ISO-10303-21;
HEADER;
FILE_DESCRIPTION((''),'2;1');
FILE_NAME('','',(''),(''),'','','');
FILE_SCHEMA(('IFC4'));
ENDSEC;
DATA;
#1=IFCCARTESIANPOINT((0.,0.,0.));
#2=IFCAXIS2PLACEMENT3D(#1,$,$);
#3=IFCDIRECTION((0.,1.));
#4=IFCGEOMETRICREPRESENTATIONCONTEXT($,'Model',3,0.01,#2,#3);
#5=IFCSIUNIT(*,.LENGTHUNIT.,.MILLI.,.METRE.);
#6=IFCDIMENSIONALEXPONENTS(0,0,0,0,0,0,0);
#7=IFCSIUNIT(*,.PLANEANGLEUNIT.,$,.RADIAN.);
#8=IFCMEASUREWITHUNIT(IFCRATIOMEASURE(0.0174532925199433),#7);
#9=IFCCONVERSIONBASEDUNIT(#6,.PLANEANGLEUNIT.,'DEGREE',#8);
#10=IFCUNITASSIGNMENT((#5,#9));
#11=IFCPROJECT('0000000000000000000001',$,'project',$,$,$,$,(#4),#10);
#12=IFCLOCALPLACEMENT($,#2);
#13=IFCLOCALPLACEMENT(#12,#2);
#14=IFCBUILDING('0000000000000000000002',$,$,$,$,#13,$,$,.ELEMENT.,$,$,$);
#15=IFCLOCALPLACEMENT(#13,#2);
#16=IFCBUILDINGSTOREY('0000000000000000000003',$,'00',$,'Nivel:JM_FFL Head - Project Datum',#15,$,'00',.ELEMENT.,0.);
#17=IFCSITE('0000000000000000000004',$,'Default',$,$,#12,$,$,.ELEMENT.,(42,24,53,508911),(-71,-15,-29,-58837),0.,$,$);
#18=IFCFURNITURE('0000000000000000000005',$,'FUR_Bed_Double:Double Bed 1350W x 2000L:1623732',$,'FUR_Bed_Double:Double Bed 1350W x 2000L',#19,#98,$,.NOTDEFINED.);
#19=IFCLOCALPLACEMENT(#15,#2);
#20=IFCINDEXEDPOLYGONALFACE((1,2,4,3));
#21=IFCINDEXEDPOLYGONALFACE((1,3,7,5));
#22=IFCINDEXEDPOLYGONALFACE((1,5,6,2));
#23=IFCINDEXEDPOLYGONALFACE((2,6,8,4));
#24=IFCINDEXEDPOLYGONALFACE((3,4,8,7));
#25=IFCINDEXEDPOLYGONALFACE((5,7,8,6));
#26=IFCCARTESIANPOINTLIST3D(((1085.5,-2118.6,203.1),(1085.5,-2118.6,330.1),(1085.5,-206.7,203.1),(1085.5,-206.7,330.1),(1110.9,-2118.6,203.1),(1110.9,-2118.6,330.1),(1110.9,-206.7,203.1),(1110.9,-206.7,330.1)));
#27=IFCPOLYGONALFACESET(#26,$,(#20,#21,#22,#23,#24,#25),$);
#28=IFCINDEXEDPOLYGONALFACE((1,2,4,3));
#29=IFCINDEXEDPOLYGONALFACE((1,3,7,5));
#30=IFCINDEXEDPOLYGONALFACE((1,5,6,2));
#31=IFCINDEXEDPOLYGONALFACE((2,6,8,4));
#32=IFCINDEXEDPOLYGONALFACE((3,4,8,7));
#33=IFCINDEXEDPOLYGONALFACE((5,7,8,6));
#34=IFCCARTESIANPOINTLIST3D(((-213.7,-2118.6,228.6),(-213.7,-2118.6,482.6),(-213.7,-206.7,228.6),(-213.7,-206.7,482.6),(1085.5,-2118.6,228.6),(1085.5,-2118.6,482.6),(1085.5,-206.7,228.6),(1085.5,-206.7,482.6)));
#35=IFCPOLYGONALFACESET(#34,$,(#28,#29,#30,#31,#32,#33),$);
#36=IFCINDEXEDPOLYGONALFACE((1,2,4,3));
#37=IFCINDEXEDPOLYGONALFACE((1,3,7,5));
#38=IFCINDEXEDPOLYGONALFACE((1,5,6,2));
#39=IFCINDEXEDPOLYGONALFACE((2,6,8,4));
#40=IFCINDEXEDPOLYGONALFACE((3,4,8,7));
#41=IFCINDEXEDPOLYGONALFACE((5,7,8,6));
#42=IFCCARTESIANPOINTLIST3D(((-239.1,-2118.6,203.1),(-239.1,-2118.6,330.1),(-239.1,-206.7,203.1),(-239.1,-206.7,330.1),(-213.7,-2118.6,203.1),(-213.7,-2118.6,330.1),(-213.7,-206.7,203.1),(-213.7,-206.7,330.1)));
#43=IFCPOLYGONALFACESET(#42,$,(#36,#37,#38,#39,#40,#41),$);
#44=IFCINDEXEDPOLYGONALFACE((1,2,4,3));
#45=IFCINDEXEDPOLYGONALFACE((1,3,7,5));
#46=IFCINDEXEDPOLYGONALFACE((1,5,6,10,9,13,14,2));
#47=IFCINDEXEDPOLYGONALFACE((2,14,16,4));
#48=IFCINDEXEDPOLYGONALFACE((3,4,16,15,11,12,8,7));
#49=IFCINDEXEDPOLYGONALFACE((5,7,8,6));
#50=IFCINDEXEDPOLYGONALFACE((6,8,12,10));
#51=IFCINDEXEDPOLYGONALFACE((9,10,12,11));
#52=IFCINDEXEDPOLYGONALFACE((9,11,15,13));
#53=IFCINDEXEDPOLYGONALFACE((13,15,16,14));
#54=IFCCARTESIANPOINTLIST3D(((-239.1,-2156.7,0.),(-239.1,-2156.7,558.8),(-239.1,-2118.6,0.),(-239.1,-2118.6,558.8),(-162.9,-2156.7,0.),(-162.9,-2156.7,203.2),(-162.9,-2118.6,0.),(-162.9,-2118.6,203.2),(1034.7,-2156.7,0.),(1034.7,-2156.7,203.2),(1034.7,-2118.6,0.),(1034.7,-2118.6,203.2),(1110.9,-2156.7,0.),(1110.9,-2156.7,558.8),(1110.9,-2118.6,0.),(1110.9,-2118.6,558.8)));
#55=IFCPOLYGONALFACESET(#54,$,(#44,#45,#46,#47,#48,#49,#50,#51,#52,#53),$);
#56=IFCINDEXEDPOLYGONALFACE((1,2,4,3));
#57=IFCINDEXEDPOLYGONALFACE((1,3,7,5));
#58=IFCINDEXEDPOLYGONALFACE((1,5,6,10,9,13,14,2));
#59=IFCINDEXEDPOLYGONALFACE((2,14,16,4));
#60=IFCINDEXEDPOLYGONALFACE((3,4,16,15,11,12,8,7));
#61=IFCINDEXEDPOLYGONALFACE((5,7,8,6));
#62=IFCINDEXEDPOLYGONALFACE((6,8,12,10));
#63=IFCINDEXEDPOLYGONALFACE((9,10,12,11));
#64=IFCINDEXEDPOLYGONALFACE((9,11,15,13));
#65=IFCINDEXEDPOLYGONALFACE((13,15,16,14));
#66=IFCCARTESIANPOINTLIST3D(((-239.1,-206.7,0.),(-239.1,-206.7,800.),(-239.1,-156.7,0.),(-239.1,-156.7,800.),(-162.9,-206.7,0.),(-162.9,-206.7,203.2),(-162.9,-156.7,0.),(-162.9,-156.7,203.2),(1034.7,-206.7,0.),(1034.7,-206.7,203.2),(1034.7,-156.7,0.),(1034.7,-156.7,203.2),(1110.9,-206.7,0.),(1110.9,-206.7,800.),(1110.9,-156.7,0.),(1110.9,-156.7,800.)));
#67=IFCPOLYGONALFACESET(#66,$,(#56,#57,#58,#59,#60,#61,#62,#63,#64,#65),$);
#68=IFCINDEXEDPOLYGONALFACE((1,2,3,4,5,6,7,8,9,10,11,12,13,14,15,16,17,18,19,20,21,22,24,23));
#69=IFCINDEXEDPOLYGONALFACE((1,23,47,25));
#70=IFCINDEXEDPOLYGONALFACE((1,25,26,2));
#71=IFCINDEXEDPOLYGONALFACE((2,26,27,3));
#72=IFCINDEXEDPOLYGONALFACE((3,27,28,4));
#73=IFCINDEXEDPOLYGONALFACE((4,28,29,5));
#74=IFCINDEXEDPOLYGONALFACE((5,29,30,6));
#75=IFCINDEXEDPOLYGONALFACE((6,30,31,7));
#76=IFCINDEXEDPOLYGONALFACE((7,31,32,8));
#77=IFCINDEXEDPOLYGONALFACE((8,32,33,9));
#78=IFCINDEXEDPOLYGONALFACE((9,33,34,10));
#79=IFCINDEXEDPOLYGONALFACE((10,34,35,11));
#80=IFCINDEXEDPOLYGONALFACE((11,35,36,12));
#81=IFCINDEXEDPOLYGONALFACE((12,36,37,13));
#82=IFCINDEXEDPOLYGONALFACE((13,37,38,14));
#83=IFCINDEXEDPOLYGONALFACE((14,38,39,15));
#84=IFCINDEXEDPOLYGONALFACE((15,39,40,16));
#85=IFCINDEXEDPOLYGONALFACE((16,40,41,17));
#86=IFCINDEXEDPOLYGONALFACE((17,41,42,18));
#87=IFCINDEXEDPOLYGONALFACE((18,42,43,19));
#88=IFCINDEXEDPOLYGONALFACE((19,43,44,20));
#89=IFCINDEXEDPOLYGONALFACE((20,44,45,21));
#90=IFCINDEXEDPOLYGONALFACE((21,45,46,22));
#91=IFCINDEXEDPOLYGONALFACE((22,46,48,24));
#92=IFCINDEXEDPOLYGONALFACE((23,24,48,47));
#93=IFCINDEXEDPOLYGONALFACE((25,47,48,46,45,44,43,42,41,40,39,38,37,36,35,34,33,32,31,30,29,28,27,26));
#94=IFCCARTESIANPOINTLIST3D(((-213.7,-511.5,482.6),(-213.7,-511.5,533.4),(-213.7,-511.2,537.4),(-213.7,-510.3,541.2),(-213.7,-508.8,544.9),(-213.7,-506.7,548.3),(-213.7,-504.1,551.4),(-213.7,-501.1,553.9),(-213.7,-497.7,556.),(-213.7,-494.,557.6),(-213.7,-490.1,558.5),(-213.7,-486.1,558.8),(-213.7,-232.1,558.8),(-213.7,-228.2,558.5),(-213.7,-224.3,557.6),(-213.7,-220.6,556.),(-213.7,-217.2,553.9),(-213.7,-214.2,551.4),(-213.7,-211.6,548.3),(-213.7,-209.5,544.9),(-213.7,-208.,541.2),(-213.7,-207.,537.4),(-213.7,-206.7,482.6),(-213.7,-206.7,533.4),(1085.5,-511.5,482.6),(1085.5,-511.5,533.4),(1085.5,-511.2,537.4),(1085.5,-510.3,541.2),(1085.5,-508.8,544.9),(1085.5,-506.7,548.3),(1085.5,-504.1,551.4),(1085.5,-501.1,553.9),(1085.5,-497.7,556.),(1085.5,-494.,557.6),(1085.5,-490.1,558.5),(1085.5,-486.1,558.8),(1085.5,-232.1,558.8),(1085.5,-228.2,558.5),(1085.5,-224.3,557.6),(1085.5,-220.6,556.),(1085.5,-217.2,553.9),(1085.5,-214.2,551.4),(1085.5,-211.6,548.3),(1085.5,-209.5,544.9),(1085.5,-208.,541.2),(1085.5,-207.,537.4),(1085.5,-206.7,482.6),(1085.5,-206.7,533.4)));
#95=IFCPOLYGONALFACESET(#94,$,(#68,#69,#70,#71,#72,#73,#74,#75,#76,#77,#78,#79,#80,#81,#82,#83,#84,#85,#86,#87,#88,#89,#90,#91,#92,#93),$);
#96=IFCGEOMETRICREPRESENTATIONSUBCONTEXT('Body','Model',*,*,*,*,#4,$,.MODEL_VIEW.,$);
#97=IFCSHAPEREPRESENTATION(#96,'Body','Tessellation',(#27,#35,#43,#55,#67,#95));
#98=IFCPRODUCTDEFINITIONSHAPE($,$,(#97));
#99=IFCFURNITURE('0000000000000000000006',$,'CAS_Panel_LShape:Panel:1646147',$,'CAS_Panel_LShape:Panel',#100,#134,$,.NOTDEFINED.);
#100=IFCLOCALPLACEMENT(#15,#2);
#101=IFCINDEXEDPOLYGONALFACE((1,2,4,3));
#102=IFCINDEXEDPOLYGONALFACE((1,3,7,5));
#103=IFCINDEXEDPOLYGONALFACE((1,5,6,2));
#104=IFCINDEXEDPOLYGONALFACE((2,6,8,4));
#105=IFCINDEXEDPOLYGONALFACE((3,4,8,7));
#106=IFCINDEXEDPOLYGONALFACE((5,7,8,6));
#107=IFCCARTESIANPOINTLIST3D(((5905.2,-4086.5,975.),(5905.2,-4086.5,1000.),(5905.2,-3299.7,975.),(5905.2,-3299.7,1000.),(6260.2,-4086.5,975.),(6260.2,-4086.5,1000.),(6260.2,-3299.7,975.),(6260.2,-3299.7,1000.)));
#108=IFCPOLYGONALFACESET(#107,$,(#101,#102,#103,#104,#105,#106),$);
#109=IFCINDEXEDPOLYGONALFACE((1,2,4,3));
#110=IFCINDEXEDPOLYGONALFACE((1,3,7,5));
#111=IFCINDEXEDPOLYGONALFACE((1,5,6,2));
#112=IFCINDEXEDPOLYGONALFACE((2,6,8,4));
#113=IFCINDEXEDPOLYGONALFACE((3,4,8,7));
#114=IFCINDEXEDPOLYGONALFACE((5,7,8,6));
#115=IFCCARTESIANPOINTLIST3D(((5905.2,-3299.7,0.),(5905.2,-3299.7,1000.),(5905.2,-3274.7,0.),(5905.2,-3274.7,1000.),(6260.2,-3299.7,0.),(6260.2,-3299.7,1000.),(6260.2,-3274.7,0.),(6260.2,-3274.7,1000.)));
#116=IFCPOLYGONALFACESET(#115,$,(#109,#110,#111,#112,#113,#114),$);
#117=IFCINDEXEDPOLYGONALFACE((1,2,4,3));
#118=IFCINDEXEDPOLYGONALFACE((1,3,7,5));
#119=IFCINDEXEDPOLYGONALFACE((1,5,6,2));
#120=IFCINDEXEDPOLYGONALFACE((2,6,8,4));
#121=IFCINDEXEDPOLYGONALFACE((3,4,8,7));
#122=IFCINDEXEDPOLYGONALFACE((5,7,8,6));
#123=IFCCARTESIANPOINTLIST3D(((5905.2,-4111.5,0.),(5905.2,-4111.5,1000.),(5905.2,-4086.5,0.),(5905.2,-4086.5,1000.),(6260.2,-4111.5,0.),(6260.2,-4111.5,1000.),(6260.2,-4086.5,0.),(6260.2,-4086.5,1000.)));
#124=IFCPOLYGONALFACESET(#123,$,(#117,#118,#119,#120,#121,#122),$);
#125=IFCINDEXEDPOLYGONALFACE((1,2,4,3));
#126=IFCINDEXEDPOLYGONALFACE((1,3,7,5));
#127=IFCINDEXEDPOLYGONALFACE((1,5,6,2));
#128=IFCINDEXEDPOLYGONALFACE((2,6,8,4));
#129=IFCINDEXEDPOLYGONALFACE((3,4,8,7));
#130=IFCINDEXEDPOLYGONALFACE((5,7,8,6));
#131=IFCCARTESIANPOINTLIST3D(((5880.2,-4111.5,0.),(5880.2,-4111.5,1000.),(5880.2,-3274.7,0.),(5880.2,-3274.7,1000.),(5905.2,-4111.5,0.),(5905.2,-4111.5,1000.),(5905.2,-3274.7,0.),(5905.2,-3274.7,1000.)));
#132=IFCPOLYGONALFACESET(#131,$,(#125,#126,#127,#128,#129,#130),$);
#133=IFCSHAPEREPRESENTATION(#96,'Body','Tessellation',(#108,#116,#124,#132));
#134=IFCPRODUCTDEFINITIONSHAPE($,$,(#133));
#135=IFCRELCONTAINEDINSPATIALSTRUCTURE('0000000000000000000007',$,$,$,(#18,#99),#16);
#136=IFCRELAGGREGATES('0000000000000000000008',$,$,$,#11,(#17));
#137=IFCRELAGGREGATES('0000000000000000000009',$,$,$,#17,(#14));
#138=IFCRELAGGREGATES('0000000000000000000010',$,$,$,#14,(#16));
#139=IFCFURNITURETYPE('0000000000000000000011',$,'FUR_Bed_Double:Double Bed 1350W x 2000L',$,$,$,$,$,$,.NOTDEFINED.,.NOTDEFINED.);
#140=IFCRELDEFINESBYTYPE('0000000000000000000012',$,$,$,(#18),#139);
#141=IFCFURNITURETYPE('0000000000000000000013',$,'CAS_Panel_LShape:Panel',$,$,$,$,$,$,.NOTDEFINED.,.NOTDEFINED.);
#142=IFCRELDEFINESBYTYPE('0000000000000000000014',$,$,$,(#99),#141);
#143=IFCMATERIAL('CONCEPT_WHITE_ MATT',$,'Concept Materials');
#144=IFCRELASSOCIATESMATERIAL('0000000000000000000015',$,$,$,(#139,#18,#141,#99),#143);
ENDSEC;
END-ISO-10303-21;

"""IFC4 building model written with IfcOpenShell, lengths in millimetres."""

from ifc_helpers import new_model, entity, si_unit, converted_unit, direction, frame, origin, place, context, subcontext, project, spatial, indexed_curve, outline, extrude, source, transform, mapped, material, type_object, type_shapes, element, save


model = new_model("IFC4")

# Units and contexts
model_context = context("Model", 3, precision=0.01, world=origin(), true_north=direction((0.0, 1.0)))
body_context = subcontext(model_context, "Body", "Model", "MODEL_VIEW")
ifc_project = project(units=[si_unit("LENGTHUNIT", "METRE", prefix="MILLI"), converted_unit("PLANEANGLEUNIT", "DEGREE", entity("IfcRatioMeasure", 0.0174532925199433), si_unit("PLANEANGLEUNIT", "RADIAN"), dimensions=[0, 0, 0, 0, 0, 0, 0])], contexts=[model_context])

# Site, building, storey
site_placement = place(None, origin())
site = spatial("IfcSite", under=ifc_project, at=site_placement, Name="Default", CompositionType="ELEMENT", RefLatitude=(42, 24, 53, 508911), RefLongitude=(-71, -15, -29, -58837), RefElevation=0.0)
building_placement = place(site_placement, origin())
building = spatial("IfcBuilding", under=site, at=building_placement, CompositionType="ELEMENT")
storey_placement = place(building_placement, origin())
storey = spatial("IfcBuildingStorey", under=building, at=storey_placement, Name="00", ObjectType="Nivel:JM_FFL Head - Project Datum", LongName="00", CompositionType="ELEMENT", Elevation=0.0)

# Shared definitions
ifc_material_1 = material(Name="CONCEPT_WHITE_ MATT", Category="Concept Materials")

# Furniture
furniture_type_1 = type_object("IfcFurnitureType", Name="FUR_Bed_Double:Double Bed 1350W x 2000L", AssemblyPlace="NOTDEFINED", PredefinedType="NOTDEFINED", material=ifc_material_1)
shared_shape_1 = source(origin(), body_context, "Body", "SweptSolid", [
    extrude(outline(indexed_curve([(-956.0, -12.7), (956.0, -12.7), (956.0, 12.7), (-956.0, 12.7), (-956.0, -12.7)], self_intersect=False)), frame((-681.4, 993.4, 203.1), z_axis=(0.0, 0.0, 1.0), x_axis=(0.0, 1.0, 0.0)), (0.0, 0.0, 1.0), 127.0),
    extrude(outline(indexed_curve([(-956.0, -649.6), (956.0, -649.6), (956.0, 649.6), (-956.0, 649.6), (-956.0, -649.6)], self_intersect=False)), frame((-19.0, 993.5, 228.6), z_axis=(0.0, 0.0, 1.0), x_axis=(0.0, 1.0, 0.0)), (0.0, 0.0, 1.0), 254.0),
    extrude(outline(indexed_curve([(-956.0, -12.7), (956.0, -12.7), (956.0, 12.7), (-956.0, 12.7), (-956.0, -12.7)], self_intersect=False)), frame((643.2, 993.4, 203.1), z_axis=(0.0, 0.0, 1.0), x_axis=(0.0, -1.0, 0.0)), (0.0, 0.0, 1.0), 127.0),
    extrude(outline(indexed_curve([(598.8, -190.5), (675.0, -190.5), (675.0, 368.3), (-675.0, 368.3), (-675.0, -190.5), (-598.8, -190.5), (-598.8, 12.7), (598.8, 12.7), (598.8, -190.5)], self_intersect=False)), frame((-19.1, 1949.4, 190.5), z_axis=(0.0, 1.0, 0.0), x_axis=(-1.0, 0.0, 0.0)), (0.0, 0.0, 1.0), 38.1),
    extrude(outline(indexed_curve([(-549.2, -675.0), (250.8, -675.0), (250.8, -598.8), (47.6, -598.8), (47.6, 598.8), (250.8, 598.8), (250.8, 675.0), (-549.2, 675.0), (-549.2, -675.0)], self_intersect=False)), frame((-19.1, -12.5, 250.8), z_axis=(0.0, 1.0, 0.0), x_axis=(0.0, 0.0, -1.0)), (0.0, 0.0, 1.0), 50.0),
    extrude(outline(indexed_curve([(-8.5, -152.4), (42.3, -152.4), (42.3, 152.4), (-8.5, 152.4), (-12.4, 152.1), (-16.3, 151.2), (-20.0, 149.6), (-23.4, 147.5), (-26.4, 145.0), (-29.0, 141.9), (-31.1, 138.5), (-32.6, 134.8), (-33.6, 131.0), (-33.9, 127.0), (-33.9, -127.0), (-33.6, -131.0), (-32.6, -134.8), (-31.1, -138.5), (-29.0, -141.9), (-26.4, -145.0), (-23.4, -147.5), (-20.0, -149.6), (-16.3, -151.2), (-12.4, -152.1), (-8.5, -152.4)], self_intersect=False)), frame((-668.6, 189.9, 524.9), z_axis=(1.0, 0.0, 0.0), x_axis=(0.0, 0.0, -1.0)), (0.0, 0.0, 1.0), 1299.2),
])
type_shapes(furniture_type_1, [shared_shape_1])
furniture_1_placement = place(storey_placement, frame((416.9, -169.2, 0.0), z_axis=(0.0, 0.0, 1.0), x_axis=(-1.0, 0.0, 0.0)))
element("IfcFurniture", 1, at=furniture_1_placement, inside=storey, type_object=furniture_type_1, material=ifc_material_1, Name="FUR_Bed_Double:Double Bed 1350W x 2000L:1623732", ObjectType="FUR_Bed_Double:Double Bed 1350W x 2000L", PredefinedType="NOTDEFINED", context=body_context, shape_type="MappedRepresentation", body=[
    mapped(shared_shape_1, transform((0.0, 0.0, 0.0), scale=1.0)),
])
furniture_type_2 = type_object("IfcFurnitureType", Name="CAS_Panel_LShape:Panel", AssemblyPlace="NOTDEFINED", PredefinedType="NOTDEFINED", material=ifc_material_1)
shared_shape_2 = source(origin(), body_context, "Body", "SweptSolid", [
    extrude(outline(indexed_curve([(-393.4, -177.5), (393.4, -177.5), (393.4, 177.5), (-393.4, 177.5), (-393.4, -177.5)], self_intersect=False)), frame((418.4, -202.5, 975.0)), (0.0, 0.0, 1.0), 25.0),
    extrude(outline(indexed_curve([(-12.5, -177.5), (12.5, -177.5), (12.5, 177.5), (-12.5, 177.5), (-12.5, -177.5)], self_intersect=False)), frame((824.3, -202.5, 0.0), z_axis=(0.0, 0.0, 1.0), x_axis=(-1.0, 0.0, 0.0)), (0.0, 0.0, 1.0), 1000.0),
    extrude(outline(indexed_curve([(-177.5, -12.5), (177.5, -12.5), (177.5, 12.5), (-177.5, 12.5), (-177.5, -12.5)], self_intersect=False)), frame((12.5, -202.5, 0.0), z_axis=(0.0, 0.0, 1.0), x_axis=(0.0, -1.0, 0.0)), (0.0, 0.0, 1.0), 1000.0),
    extrude(outline(indexed_curve([(-12.5, -418.4), (12.5, -418.4), (12.5, 418.4), (-12.5, 418.4), (-12.5, -418.4)], self_intersect=False)), frame((418.4, -12.5, 0.0), z_axis=(0.0, 0.0, 1.0), x_axis=(0.0, -1.0, 0.0)), (0.0, 0.0, 1.0), 1000.0),
])
type_shapes(furniture_type_2, [shared_shape_2])
furniture_2_placement = place(storey_placement, frame((5880.2, -4111.5, 0.0), z_axis=(0.0, 0.0, 1.0), x_axis=(0.0, 1.0, 0.0)))
element("IfcFurniture", 2, at=furniture_2_placement, inside=storey, type_object=furniture_type_2, material=ifc_material_1, Name="CAS_Panel_LShape:Panel:1646147", ObjectType="CAS_Panel_LShape:Panel", PredefinedType="NOTDEFINED", context=body_context, shape_type="MappedRepresentation", body=[
    mapped(shared_shape_2, transform((0.0, 0.0, 0.0), scale=1.0)),
])

save(model, "model.ifc")
